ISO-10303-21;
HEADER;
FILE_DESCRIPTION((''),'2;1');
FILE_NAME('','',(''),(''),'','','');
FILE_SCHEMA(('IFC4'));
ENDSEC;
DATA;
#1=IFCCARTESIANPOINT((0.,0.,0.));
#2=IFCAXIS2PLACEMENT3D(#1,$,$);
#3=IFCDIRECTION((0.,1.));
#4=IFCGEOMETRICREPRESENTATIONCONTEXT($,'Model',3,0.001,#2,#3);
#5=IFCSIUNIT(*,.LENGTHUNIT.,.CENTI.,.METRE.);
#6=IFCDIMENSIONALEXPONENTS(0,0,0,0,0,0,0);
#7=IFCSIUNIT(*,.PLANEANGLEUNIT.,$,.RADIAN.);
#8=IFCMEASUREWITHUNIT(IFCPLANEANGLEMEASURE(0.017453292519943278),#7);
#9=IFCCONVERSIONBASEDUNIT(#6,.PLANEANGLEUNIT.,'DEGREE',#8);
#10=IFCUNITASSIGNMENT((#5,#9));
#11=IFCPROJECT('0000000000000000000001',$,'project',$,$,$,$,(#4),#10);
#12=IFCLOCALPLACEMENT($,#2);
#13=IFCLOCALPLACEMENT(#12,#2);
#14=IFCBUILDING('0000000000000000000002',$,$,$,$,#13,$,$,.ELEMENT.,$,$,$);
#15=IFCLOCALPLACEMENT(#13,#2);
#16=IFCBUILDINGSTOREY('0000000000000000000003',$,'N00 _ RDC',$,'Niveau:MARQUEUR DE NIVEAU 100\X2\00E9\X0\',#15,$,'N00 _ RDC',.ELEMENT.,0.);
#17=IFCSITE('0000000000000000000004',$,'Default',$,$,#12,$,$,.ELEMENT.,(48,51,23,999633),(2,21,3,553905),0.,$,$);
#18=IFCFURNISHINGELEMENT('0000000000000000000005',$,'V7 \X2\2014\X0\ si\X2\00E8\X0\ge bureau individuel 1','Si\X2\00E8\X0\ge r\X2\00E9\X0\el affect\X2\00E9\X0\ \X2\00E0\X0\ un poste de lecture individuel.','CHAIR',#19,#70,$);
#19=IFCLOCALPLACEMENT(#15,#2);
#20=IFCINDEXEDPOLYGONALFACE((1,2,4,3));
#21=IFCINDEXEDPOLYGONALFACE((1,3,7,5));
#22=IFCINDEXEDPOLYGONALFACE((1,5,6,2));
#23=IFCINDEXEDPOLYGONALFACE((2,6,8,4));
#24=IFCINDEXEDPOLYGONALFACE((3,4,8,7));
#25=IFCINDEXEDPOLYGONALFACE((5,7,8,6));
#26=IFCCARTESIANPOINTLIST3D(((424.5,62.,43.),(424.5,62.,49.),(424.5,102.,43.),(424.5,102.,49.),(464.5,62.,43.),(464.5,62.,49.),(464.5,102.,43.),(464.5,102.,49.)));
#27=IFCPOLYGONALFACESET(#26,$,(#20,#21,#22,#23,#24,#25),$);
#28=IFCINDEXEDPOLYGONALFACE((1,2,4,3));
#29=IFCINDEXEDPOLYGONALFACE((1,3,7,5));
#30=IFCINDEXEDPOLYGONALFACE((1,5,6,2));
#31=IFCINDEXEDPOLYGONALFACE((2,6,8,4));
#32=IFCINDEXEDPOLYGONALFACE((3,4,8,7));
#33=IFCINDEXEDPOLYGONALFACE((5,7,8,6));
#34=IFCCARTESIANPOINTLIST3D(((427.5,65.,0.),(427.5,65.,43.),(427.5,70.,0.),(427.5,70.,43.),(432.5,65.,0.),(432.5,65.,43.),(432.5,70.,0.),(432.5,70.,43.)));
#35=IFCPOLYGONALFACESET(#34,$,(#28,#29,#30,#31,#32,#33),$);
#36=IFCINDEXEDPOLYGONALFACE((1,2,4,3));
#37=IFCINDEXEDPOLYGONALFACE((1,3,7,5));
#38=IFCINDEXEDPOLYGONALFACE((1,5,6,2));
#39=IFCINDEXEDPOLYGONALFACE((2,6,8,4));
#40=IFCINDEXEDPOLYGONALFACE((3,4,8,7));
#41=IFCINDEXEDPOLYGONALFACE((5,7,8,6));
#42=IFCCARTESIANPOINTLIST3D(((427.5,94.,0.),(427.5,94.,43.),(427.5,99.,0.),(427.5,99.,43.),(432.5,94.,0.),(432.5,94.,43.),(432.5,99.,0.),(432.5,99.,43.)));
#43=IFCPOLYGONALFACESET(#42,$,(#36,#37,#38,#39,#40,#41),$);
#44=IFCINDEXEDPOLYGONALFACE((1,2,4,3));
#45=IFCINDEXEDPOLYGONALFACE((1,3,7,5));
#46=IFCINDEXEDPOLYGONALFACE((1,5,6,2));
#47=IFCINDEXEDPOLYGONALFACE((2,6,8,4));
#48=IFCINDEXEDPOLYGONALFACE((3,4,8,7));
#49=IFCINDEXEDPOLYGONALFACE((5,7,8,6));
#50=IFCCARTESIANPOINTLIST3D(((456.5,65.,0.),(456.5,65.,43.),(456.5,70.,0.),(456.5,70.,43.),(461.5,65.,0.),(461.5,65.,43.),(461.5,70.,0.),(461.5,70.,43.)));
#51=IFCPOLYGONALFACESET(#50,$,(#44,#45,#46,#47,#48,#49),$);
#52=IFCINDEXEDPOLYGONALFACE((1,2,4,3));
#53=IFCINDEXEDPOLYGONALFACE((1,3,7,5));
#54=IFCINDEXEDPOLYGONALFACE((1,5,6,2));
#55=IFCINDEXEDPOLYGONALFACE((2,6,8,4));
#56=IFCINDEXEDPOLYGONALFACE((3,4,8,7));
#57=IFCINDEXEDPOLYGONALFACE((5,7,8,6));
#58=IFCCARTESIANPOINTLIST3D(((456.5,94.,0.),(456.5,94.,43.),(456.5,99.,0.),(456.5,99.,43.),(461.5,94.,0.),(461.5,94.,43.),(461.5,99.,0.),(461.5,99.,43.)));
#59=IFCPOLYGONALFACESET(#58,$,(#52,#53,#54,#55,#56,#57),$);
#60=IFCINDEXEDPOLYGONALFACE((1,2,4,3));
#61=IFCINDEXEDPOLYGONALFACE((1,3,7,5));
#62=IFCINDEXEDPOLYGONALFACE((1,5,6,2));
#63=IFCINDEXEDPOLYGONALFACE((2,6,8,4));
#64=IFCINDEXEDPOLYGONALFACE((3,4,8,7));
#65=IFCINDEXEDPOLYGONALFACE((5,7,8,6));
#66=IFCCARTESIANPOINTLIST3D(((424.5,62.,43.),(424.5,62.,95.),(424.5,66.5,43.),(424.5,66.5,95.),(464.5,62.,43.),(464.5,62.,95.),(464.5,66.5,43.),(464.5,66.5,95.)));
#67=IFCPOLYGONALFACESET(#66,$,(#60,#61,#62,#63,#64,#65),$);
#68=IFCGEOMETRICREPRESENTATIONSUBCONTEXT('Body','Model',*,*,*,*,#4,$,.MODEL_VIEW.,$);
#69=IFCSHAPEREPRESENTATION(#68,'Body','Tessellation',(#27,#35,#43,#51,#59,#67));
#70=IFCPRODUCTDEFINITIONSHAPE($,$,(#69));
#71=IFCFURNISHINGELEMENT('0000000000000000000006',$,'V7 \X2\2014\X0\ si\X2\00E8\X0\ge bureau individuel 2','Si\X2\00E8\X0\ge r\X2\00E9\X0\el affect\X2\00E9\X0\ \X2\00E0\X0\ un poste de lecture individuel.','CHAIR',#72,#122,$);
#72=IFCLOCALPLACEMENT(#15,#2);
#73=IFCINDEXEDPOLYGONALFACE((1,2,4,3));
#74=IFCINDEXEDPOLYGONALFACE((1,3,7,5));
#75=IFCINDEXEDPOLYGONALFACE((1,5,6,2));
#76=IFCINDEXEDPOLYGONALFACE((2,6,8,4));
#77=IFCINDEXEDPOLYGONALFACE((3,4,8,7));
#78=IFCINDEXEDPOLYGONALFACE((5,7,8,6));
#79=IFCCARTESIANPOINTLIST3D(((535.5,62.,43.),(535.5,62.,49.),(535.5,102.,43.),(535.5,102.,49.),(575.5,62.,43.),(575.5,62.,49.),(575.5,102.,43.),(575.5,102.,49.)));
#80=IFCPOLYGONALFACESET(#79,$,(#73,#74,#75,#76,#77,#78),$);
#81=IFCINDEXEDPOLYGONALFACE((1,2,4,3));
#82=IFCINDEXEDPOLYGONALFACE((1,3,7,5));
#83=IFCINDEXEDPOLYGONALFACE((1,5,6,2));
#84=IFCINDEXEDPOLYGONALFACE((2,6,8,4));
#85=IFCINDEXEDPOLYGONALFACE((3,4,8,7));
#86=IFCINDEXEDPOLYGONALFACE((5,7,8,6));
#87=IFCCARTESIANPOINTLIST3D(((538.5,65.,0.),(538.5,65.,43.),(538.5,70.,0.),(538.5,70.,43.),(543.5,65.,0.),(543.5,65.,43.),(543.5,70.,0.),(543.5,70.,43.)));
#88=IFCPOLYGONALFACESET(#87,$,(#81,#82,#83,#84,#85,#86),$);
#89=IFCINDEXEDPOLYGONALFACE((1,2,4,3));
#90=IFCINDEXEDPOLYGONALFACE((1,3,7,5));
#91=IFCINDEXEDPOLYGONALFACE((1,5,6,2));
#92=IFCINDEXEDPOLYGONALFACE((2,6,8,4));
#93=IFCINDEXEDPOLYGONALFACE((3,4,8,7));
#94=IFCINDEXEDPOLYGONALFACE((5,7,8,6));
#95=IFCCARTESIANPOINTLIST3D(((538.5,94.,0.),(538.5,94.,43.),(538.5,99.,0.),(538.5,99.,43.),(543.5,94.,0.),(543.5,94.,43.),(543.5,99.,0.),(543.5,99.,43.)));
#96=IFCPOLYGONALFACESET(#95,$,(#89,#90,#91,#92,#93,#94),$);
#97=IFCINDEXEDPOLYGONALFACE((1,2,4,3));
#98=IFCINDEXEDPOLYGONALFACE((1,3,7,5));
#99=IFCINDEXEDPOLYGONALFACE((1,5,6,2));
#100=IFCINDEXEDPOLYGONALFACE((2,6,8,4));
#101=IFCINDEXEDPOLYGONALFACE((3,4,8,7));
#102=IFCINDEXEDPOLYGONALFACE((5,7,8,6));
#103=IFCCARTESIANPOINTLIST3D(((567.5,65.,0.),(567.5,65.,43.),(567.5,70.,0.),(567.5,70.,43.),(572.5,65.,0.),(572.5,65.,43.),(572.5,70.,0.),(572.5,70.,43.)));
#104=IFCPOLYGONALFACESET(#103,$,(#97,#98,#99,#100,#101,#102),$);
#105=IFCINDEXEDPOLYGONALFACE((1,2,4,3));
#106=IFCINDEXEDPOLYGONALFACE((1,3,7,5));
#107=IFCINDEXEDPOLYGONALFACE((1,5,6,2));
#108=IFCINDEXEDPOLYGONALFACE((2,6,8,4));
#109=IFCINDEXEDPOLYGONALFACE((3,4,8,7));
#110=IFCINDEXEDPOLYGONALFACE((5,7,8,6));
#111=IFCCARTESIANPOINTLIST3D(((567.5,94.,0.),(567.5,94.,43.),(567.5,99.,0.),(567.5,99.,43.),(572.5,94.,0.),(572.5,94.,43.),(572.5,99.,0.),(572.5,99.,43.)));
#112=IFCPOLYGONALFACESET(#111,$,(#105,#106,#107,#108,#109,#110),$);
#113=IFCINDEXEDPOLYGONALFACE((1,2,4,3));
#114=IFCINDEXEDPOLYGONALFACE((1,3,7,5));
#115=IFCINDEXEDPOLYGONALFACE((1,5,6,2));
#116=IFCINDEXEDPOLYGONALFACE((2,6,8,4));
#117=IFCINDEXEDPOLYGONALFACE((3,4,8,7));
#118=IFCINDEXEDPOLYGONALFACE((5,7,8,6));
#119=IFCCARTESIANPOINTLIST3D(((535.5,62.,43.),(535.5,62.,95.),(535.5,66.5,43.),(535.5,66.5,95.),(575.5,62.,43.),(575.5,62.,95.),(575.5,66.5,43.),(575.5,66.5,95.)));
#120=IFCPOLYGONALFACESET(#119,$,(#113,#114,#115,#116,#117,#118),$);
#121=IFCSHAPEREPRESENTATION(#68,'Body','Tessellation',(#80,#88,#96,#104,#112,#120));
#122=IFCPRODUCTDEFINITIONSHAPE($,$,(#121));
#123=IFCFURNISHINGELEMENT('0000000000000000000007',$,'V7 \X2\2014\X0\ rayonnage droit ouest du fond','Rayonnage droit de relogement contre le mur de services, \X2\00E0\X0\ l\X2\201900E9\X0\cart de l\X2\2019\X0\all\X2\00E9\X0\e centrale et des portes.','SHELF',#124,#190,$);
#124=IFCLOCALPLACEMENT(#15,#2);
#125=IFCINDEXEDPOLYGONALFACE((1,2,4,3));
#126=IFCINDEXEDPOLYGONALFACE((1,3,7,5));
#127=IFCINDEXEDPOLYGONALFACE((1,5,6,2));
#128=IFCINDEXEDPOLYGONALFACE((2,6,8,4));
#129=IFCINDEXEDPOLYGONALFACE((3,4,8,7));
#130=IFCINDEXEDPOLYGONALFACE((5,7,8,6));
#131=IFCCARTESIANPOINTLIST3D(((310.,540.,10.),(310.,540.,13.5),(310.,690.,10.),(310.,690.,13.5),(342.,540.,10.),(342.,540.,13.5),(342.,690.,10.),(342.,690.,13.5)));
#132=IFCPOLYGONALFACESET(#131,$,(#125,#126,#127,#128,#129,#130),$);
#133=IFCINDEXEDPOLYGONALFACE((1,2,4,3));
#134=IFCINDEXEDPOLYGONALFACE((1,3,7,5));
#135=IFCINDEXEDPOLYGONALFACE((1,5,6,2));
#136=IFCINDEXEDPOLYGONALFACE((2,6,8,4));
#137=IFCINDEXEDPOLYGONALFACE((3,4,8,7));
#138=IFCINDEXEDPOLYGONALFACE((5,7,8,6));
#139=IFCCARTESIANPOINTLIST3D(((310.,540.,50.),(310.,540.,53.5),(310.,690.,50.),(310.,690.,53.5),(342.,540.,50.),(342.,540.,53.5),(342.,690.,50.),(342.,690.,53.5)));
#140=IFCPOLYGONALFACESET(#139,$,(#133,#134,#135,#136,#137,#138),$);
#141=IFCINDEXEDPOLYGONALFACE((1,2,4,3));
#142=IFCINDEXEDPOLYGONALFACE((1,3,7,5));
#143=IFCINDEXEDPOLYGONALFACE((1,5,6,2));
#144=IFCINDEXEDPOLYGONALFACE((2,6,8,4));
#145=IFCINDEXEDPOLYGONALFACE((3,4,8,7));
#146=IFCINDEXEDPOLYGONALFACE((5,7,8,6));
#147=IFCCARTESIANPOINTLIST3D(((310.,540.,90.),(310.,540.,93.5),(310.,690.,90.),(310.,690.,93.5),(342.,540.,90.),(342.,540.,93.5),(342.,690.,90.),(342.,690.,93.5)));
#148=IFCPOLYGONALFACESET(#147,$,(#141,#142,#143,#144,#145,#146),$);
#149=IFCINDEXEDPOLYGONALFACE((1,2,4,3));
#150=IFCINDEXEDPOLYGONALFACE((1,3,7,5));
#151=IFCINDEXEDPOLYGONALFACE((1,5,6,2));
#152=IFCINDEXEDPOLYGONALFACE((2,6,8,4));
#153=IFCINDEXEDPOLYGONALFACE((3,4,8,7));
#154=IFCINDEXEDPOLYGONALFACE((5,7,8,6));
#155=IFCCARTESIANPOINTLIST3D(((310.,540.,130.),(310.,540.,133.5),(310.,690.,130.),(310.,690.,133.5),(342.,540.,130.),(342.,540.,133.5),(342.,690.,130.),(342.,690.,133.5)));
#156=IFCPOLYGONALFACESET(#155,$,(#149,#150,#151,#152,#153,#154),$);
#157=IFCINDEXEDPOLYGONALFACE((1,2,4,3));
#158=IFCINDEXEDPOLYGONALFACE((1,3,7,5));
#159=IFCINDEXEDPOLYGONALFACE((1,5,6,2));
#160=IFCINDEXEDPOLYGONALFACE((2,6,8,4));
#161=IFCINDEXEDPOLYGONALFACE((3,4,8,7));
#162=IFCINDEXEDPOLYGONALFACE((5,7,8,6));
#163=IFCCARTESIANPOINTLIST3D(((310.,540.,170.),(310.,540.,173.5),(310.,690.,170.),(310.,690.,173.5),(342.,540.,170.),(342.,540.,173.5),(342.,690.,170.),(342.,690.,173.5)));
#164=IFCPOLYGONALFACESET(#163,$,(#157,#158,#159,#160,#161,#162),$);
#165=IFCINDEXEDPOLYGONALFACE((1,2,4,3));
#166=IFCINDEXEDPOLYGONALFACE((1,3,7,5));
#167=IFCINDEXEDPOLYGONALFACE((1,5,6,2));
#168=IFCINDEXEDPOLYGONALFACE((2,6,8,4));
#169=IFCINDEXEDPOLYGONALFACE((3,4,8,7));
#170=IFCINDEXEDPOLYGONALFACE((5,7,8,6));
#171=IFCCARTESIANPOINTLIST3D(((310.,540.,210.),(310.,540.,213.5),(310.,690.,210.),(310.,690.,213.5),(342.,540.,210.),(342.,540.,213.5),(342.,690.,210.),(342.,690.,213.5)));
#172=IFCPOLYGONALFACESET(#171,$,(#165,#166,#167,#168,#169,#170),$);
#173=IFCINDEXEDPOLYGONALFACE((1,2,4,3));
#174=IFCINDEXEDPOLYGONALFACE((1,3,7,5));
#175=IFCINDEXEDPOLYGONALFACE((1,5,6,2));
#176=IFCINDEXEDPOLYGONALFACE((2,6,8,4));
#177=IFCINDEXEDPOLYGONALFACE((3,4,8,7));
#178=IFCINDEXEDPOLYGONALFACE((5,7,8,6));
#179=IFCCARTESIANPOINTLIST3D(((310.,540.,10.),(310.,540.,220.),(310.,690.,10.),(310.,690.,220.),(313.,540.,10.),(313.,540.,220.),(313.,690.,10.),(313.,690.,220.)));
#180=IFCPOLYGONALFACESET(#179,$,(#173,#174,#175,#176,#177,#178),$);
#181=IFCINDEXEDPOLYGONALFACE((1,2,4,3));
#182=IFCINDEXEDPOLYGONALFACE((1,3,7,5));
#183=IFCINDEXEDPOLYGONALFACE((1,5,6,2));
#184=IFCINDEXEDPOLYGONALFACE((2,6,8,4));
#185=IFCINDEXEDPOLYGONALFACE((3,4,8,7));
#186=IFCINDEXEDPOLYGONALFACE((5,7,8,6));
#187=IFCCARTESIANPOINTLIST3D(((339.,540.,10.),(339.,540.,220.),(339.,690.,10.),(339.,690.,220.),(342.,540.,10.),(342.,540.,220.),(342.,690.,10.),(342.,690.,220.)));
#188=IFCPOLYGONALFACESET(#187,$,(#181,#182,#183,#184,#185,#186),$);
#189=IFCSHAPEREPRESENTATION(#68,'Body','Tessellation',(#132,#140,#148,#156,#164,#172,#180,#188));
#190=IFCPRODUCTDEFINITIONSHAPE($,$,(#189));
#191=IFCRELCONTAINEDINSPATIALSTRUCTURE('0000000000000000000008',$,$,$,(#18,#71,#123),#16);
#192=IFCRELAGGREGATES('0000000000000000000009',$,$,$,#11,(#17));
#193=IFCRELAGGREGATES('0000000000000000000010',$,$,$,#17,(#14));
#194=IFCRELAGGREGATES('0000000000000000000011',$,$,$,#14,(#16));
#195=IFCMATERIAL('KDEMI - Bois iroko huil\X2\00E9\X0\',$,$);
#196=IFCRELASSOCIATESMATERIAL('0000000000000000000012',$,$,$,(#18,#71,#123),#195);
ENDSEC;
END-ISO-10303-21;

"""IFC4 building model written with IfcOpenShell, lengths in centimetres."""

from ifc_helpers import new_model, entity, si_unit, converted_unit, direction, frame, frame_2d, origin, origin_with_axes, place, context, subcontext, project, spatial, rectangle, extrude, material, element, save


model = new_model("IFC4")

# Units and contexts
model_context = context("Model", 3, precision=0.001, world=origin(), true_north=direction((0.0, 1.0)))
body_context = subcontext(model_context, "Body", "Model", "MODEL_VIEW")
ifc_project = project(units=[si_unit("LENGTHUNIT", "METRE", prefix="CENTI"), converted_unit("PLANEANGLEUNIT", "DEGREE", entity("IfcPlaneAngleMeasure", 0.017453292519943278), si_unit("PLANEANGLEUNIT", "RADIAN"), dimensions=[0, 0, 0, 0, 0, 0, 0])], contexts=[model_context])

# Site, building, storey
site_placement = place(None, origin())
site = spatial("IfcSite", under=ifc_project, at=site_placement, Name="Default", CompositionType="ELEMENT", RefLatitude=(48, 51, 23, 999633), RefLongitude=(2, 21, 3, 553905), RefElevation=0.0)
building_placement = place(site_placement, origin())
building = spatial("IfcBuilding", under=site, at=building_placement, CompositionType="ELEMENT")
storey_placement = place(building_placement, origin())
storey = spatial("IfcBuildingStorey", under=building, at=storey_placement, Name="N00 _ RDC", ObjectType="Niveau:MARQUEUR DE NIVEAU 100é", LongName="N00 _ RDC", CompositionType="ELEMENT", Elevation=0.0)

# Furnishing elements
ifc_material_1 = material(Name="KDEMI - Bois iroko huilé")
furnishing_1_placement = place(storey_placement, origin_with_axes())
element("IfcFurnishingElement", 1, at=furnishing_1_placement, inside=storey, material=ifc_material_1, Name="V7 — siège bureau individuel 1", Description="Siège réel affecté à un poste de lecture individuel.", ObjectType="CHAIR", context=body_context, shape_type="SweptSolid", body=[
    extrude(rectangle(XDim=40.0, YDim=40.0, at=frame_2d((444.5, 82.0))), frame((0.0, 0.0, 43.0)), (0.0, 0.0, 1.0), 6.0),
    extrude(rectangle(XDim=5.0, YDim=5.0, at=frame_2d((430.0, 67.5))), origin(), (0.0, 0.0, 1.0), 43.0),
    extrude(rectangle(XDim=5.0, YDim=5.0, at=frame_2d((430.0, 96.5))), origin(), (0.0, 0.0, 1.0), 43.0),
    extrude(rectangle(XDim=5.0, YDim=5.0, at=frame_2d((459.0, 67.5))), origin(), (0.0, 0.0, 1.0), 43.0),
    extrude(rectangle(XDim=5.0, YDim=5.0, at=frame_2d((459.0, 96.5))), origin(), (0.0, 0.0, 1.0), 43.0),
    extrude(rectangle(XDim=40.0, YDim=4.5, at=frame_2d((444.5, 64.25))), frame((0.0, 0.0, 43.0)), (0.0, 0.0, 1.0), 52.0),
])
furnishing_2_placement = place(storey_placement, origin_with_axes())
element("IfcFurnishingElement", 2, at=furnishing_2_placement, inside=storey, material=ifc_material_1, Name="V7 — siège bureau individuel 2", Description="Siège réel affecté à un poste de lecture individuel.", ObjectType="CHAIR", context=body_context, shape_type="SweptSolid", body=[
    extrude(rectangle(XDim=40.0, YDim=40.0, at=frame_2d((555.5, 82.0))), frame((0.0, 0.0, 43.0)), (0.0, 0.0, 1.0), 6.0),
    extrude(rectangle(XDim=5.0, YDim=5.0, at=frame_2d((541.0, 67.5))), origin(), (0.0, 0.0, 1.0), 43.0),
    extrude(rectangle(XDim=5.0, YDim=5.0, at=frame_2d((541.0, 96.5))), origin(), (0.0, 0.0, 1.0), 43.0),
    extrude(rectangle(XDim=5.0, YDim=5.0, at=frame_2d((570.0, 67.5))), origin(), (0.0, 0.0, 1.0), 43.0),
    extrude(rectangle(XDim=5.0, YDim=5.0, at=frame_2d((570.0, 96.5))), origin(), (0.0, 0.0, 1.0), 43.0),
    extrude(rectangle(XDim=40.0, YDim=4.5, at=frame_2d((555.5, 64.25))), frame((0.0, 0.0, 43.0)), (0.0, 0.0, 1.0), 52.0),
])
furnishing_3_placement = place(storey_placement, origin_with_axes())
element("IfcFurnishingElement", 3, at=furnishing_3_placement, inside=storey, material=ifc_material_1, Name="V7 — rayonnage droit ouest du fond", Description="Rayonnage droit de relogement contre le mur de services, à l’écart de l’allée centrale et des portes.", ObjectType="SHELF", context=body_context, shape_type="SweptSolid", body=[
    extrude(rectangle(XDim=32.0, YDim=150.0, at=frame_2d((326.0, 615.0))), frame((0.0, 0.0, 10.0)), (0.0, 0.0, 1.0), 3.5),
    extrude(rectangle(XDim=32.0, YDim=150.0, at=frame_2d((326.0, 615.0))), frame((0.0, 0.0, 50.0)), (0.0, 0.0, 1.0), 3.5),
    extrude(rectangle(XDim=32.0, YDim=150.0, at=frame_2d((326.0, 615.0))), frame((0.0, 0.0, 90.0)), (0.0, 0.0, 1.0), 3.5),
    extrude(rectangle(XDim=32.0, YDim=150.0, at=frame_2d((326.0, 615.0))), frame((0.0, 0.0, 130.0)), (0.0, 0.0, 1.0), 3.5),
    extrude(rectangle(XDim=32.0, YDim=150.0, at=frame_2d((326.0, 615.0))), frame((0.0, 0.0, 170.0)), (0.0, 0.0, 1.0), 3.5),
    extrude(rectangle(XDim=32.0, YDim=150.0, at=frame_2d((326.0, 615.0))), frame((0.0, 0.0, 210.0)), (0.0, 0.0, 1.0), 3.5),
    extrude(rectangle(XDim=3.0, YDim=150.0, at=frame_2d((311.5, 615.0))), frame((0.0, 0.0, 10.0)), (0.0, 0.0, 1.0), 210.0),
    extrude(rectangle(XDim=3.0, YDim=150.0, at=frame_2d((340.5, 615.0))), frame((0.0, 0.0, 10.0)), (0.0, 0.0, 1.0), 210.0),
])

save(model, "model.ifc")
